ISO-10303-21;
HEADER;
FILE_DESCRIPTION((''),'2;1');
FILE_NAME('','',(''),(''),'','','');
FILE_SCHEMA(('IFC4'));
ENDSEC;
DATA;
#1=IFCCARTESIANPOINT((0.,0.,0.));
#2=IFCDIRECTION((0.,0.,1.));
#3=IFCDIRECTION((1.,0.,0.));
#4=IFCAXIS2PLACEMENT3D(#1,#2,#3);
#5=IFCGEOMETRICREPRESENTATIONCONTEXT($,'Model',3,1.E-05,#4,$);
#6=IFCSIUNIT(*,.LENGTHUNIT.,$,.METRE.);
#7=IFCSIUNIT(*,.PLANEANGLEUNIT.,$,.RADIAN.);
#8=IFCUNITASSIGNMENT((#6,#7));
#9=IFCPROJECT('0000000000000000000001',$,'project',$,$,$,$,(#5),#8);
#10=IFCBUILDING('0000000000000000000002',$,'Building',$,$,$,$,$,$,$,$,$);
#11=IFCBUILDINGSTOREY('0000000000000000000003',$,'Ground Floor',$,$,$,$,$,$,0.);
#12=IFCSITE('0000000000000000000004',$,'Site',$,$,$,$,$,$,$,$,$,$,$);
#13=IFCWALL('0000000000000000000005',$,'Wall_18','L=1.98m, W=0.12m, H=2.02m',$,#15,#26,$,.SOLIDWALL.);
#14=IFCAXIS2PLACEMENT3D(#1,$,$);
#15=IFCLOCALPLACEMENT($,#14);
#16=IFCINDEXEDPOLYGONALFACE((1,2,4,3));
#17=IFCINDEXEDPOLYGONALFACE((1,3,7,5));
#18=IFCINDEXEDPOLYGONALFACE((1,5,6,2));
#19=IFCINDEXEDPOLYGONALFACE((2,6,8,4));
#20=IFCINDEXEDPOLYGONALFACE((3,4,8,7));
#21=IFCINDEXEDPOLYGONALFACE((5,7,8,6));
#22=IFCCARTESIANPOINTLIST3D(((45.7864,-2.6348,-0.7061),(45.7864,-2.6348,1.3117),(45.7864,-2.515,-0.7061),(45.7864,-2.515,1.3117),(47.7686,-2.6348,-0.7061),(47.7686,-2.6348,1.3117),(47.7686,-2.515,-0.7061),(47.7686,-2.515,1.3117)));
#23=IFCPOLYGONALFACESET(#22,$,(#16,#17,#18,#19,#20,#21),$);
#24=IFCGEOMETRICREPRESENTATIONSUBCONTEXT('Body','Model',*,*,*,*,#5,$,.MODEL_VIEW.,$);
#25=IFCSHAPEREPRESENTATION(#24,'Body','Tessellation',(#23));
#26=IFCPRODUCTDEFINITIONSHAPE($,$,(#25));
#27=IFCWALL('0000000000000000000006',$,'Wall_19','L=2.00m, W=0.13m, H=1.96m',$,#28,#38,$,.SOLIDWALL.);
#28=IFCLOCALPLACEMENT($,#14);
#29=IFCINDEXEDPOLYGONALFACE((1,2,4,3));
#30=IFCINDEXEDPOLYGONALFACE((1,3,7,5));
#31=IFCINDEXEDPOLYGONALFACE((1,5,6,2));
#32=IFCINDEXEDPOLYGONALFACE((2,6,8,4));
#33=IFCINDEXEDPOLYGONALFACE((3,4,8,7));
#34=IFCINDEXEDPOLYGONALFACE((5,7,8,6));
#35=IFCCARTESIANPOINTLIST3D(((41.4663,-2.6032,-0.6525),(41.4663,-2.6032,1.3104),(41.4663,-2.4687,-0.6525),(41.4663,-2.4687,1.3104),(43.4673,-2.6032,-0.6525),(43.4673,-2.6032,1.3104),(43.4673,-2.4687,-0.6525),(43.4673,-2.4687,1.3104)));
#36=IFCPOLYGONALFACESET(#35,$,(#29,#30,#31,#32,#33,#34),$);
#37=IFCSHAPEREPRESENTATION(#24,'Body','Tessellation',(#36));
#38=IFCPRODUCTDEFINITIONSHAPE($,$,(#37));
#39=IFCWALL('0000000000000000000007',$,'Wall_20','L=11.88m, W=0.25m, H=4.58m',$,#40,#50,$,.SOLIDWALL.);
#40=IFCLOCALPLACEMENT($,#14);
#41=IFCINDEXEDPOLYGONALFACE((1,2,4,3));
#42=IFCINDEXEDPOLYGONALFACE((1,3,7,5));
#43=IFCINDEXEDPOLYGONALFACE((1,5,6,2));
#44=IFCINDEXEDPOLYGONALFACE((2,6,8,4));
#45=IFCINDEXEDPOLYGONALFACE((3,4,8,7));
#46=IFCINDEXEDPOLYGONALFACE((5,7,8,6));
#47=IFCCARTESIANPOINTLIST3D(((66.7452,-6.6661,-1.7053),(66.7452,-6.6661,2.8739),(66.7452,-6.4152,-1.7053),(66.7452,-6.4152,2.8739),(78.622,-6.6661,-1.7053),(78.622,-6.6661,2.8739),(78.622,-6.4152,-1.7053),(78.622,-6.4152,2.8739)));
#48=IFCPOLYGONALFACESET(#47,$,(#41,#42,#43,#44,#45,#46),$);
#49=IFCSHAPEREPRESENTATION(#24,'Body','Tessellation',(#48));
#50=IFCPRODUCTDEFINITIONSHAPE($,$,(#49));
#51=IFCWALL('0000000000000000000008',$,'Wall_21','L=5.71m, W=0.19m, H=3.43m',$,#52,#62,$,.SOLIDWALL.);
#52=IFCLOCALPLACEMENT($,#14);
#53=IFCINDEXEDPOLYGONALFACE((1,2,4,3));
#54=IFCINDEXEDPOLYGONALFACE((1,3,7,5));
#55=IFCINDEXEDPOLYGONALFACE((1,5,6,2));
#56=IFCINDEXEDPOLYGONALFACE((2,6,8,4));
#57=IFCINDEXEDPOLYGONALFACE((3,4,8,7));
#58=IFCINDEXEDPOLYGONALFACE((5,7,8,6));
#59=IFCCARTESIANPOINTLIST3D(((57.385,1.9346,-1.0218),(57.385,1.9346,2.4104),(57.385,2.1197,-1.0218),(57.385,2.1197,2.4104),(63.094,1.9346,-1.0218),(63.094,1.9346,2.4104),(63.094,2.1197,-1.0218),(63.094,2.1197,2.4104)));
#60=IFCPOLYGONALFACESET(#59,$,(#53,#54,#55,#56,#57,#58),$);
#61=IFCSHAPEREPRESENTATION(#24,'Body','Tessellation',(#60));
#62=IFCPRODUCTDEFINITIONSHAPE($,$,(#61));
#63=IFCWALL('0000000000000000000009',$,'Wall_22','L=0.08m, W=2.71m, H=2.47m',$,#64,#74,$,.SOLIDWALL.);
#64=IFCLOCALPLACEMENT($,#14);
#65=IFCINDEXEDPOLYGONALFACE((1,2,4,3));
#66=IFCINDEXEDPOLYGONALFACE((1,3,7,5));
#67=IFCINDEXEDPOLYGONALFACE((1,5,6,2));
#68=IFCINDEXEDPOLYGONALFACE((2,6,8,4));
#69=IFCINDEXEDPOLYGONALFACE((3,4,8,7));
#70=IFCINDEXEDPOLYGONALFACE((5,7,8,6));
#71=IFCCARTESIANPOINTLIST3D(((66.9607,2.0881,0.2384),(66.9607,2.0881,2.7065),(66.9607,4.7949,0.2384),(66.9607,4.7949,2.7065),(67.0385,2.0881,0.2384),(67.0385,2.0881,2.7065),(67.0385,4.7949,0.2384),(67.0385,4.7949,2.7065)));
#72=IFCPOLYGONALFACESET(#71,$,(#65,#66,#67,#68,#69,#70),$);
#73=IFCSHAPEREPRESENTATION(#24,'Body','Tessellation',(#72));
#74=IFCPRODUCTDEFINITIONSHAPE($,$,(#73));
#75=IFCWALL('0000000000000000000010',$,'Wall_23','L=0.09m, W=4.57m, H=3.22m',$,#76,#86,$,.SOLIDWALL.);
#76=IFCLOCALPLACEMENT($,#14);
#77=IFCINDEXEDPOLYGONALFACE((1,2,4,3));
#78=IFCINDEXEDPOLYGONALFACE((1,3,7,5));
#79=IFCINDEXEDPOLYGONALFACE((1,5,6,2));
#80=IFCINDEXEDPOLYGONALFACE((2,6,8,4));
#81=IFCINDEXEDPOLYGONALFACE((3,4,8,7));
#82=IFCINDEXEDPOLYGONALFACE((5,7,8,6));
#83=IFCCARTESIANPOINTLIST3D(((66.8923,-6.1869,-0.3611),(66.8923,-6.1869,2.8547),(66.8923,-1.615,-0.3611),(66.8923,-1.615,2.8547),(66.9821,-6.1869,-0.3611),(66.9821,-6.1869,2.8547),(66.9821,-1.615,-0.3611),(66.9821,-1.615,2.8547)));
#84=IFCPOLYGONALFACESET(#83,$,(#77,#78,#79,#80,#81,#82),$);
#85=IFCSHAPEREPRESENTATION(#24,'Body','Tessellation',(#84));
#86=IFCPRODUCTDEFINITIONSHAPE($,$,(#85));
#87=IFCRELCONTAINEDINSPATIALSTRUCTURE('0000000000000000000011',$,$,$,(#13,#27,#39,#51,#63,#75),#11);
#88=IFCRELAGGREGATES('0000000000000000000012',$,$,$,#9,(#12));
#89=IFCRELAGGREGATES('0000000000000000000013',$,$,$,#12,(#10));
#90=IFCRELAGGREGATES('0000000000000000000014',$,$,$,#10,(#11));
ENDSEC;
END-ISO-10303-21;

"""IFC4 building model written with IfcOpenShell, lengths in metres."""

from ifc_helpers import new_model, si_unit, frame, origin_with_axes, origin_2d, context, subcontext, project, spatial, rectangle, extrude, element, save


model = new_model("IFC4")

# Units and contexts
model_context = context("Model", 3, precision=1e-05, world=origin_with_axes())
body_context = subcontext(model_context, "Body", "Model", "MODEL_VIEW")
ifc_project = project(units=[si_unit("LENGTHUNIT", "METRE"), si_unit("PLANEANGLEUNIT", "RADIAN")], contexts=[model_context])

# Site, building, storey
site = spatial("IfcSite", under=ifc_project, Name="Site")
building = spatial("IfcBuilding", under=site, Name="Building")
storey = spatial("IfcBuildingStorey", under=building, Name="Ground Floor", Elevation=0.0)

# Walls
element("IfcWall", 1, inside=storey, Name="Wall_18", Description="L=1.98m, W=0.12m, H=2.02m", PredefinedType="SOLIDWALL", context=body_context, shape_type="SweptSolid", body=[
    extrude(rectangle(XDim=1.9822, YDim=0.1198, at=origin_2d()), frame((46.7775, -2.5749, -0.7061), z_axis=(0.0, 0.0, 1.0), x_axis=(1.0, 0.0, 0.0)), (0.0, 0.0, 1.0), 2.0178),
])
element("IfcWall", 2, inside=storey, Name="Wall_19", Description="L=2.00m, W=0.13m, H=1.96m", PredefinedType="SOLIDWALL", context=body_context, shape_type="SweptSolid", body=[
    extrude(rectangle(XDim=2.001, YDim=0.1345, at=origin_2d()), frame((42.4668, -2.536, -0.6525), z_axis=(0.0, 0.0, 1.0), x_axis=(1.0, 0.0, 0.0)), (0.0, 0.0, 1.0), 1.9629),
])
element("IfcWall", 3, inside=storey, Name="Wall_20", Description="L=11.88m, W=0.25m, H=4.58m", PredefinedType="SOLIDWALL", context=body_context, shape_type="SweptSolid", body=[
    extrude(rectangle(XDim=11.8769, YDim=0.2509, at=origin_2d()), frame((72.6836, -6.5406, -1.7053), z_axis=(0.0, 0.0, 1.0), x_axis=(1.0, 0.0, 0.0)), (0.0, 0.0, 1.0), 4.5792),
])
element("IfcWall", 4, inside=storey, Name="Wall_21", Description="L=5.71m, W=0.19m, H=3.43m", PredefinedType="SOLIDWALL", context=body_context, shape_type="SweptSolid", body=[
    extrude(rectangle(XDim=5.709, YDim=0.1851, at=origin_2d()), frame((60.2395, 2.0271, -1.0218), z_axis=(0.0, 0.0, 1.0), x_axis=(1.0, 0.0, 0.0)), (0.0, 0.0, 1.0), 3.4322),
])
element("IfcWall", 5, inside=storey, Name="Wall_22", Description="L=0.08m, W=2.71m, H=2.47m", PredefinedType="SOLIDWALL", context=body_context, shape_type="SweptSolid", body=[
    extrude(rectangle(XDim=0.0778, YDim=2.7067, at=origin_2d()), frame((66.9996, 3.4415, 0.2384), z_axis=(0.0, 0.0, 1.0), x_axis=(1.0, 0.0, 0.0)), (0.0, 0.0, 1.0), 2.468),
])
element("IfcWall", 6, inside=storey, Name="Wall_23", Description="L=0.09m, W=4.57m, H=3.22m", PredefinedType="SOLIDWALL", context=body_context, shape_type="SweptSolid", body=[
    extrude(rectangle(XDim=0.0898, YDim=4.5719, at=origin_2d()), frame((66.9372, -3.901, -0.3611), z_axis=(0.0, 0.0, 1.0), x_axis=(1.0, 0.0, 0.0)), (0.0, 0.0, 1.0), 3.2157),
])

save(model, "model.ifc")
